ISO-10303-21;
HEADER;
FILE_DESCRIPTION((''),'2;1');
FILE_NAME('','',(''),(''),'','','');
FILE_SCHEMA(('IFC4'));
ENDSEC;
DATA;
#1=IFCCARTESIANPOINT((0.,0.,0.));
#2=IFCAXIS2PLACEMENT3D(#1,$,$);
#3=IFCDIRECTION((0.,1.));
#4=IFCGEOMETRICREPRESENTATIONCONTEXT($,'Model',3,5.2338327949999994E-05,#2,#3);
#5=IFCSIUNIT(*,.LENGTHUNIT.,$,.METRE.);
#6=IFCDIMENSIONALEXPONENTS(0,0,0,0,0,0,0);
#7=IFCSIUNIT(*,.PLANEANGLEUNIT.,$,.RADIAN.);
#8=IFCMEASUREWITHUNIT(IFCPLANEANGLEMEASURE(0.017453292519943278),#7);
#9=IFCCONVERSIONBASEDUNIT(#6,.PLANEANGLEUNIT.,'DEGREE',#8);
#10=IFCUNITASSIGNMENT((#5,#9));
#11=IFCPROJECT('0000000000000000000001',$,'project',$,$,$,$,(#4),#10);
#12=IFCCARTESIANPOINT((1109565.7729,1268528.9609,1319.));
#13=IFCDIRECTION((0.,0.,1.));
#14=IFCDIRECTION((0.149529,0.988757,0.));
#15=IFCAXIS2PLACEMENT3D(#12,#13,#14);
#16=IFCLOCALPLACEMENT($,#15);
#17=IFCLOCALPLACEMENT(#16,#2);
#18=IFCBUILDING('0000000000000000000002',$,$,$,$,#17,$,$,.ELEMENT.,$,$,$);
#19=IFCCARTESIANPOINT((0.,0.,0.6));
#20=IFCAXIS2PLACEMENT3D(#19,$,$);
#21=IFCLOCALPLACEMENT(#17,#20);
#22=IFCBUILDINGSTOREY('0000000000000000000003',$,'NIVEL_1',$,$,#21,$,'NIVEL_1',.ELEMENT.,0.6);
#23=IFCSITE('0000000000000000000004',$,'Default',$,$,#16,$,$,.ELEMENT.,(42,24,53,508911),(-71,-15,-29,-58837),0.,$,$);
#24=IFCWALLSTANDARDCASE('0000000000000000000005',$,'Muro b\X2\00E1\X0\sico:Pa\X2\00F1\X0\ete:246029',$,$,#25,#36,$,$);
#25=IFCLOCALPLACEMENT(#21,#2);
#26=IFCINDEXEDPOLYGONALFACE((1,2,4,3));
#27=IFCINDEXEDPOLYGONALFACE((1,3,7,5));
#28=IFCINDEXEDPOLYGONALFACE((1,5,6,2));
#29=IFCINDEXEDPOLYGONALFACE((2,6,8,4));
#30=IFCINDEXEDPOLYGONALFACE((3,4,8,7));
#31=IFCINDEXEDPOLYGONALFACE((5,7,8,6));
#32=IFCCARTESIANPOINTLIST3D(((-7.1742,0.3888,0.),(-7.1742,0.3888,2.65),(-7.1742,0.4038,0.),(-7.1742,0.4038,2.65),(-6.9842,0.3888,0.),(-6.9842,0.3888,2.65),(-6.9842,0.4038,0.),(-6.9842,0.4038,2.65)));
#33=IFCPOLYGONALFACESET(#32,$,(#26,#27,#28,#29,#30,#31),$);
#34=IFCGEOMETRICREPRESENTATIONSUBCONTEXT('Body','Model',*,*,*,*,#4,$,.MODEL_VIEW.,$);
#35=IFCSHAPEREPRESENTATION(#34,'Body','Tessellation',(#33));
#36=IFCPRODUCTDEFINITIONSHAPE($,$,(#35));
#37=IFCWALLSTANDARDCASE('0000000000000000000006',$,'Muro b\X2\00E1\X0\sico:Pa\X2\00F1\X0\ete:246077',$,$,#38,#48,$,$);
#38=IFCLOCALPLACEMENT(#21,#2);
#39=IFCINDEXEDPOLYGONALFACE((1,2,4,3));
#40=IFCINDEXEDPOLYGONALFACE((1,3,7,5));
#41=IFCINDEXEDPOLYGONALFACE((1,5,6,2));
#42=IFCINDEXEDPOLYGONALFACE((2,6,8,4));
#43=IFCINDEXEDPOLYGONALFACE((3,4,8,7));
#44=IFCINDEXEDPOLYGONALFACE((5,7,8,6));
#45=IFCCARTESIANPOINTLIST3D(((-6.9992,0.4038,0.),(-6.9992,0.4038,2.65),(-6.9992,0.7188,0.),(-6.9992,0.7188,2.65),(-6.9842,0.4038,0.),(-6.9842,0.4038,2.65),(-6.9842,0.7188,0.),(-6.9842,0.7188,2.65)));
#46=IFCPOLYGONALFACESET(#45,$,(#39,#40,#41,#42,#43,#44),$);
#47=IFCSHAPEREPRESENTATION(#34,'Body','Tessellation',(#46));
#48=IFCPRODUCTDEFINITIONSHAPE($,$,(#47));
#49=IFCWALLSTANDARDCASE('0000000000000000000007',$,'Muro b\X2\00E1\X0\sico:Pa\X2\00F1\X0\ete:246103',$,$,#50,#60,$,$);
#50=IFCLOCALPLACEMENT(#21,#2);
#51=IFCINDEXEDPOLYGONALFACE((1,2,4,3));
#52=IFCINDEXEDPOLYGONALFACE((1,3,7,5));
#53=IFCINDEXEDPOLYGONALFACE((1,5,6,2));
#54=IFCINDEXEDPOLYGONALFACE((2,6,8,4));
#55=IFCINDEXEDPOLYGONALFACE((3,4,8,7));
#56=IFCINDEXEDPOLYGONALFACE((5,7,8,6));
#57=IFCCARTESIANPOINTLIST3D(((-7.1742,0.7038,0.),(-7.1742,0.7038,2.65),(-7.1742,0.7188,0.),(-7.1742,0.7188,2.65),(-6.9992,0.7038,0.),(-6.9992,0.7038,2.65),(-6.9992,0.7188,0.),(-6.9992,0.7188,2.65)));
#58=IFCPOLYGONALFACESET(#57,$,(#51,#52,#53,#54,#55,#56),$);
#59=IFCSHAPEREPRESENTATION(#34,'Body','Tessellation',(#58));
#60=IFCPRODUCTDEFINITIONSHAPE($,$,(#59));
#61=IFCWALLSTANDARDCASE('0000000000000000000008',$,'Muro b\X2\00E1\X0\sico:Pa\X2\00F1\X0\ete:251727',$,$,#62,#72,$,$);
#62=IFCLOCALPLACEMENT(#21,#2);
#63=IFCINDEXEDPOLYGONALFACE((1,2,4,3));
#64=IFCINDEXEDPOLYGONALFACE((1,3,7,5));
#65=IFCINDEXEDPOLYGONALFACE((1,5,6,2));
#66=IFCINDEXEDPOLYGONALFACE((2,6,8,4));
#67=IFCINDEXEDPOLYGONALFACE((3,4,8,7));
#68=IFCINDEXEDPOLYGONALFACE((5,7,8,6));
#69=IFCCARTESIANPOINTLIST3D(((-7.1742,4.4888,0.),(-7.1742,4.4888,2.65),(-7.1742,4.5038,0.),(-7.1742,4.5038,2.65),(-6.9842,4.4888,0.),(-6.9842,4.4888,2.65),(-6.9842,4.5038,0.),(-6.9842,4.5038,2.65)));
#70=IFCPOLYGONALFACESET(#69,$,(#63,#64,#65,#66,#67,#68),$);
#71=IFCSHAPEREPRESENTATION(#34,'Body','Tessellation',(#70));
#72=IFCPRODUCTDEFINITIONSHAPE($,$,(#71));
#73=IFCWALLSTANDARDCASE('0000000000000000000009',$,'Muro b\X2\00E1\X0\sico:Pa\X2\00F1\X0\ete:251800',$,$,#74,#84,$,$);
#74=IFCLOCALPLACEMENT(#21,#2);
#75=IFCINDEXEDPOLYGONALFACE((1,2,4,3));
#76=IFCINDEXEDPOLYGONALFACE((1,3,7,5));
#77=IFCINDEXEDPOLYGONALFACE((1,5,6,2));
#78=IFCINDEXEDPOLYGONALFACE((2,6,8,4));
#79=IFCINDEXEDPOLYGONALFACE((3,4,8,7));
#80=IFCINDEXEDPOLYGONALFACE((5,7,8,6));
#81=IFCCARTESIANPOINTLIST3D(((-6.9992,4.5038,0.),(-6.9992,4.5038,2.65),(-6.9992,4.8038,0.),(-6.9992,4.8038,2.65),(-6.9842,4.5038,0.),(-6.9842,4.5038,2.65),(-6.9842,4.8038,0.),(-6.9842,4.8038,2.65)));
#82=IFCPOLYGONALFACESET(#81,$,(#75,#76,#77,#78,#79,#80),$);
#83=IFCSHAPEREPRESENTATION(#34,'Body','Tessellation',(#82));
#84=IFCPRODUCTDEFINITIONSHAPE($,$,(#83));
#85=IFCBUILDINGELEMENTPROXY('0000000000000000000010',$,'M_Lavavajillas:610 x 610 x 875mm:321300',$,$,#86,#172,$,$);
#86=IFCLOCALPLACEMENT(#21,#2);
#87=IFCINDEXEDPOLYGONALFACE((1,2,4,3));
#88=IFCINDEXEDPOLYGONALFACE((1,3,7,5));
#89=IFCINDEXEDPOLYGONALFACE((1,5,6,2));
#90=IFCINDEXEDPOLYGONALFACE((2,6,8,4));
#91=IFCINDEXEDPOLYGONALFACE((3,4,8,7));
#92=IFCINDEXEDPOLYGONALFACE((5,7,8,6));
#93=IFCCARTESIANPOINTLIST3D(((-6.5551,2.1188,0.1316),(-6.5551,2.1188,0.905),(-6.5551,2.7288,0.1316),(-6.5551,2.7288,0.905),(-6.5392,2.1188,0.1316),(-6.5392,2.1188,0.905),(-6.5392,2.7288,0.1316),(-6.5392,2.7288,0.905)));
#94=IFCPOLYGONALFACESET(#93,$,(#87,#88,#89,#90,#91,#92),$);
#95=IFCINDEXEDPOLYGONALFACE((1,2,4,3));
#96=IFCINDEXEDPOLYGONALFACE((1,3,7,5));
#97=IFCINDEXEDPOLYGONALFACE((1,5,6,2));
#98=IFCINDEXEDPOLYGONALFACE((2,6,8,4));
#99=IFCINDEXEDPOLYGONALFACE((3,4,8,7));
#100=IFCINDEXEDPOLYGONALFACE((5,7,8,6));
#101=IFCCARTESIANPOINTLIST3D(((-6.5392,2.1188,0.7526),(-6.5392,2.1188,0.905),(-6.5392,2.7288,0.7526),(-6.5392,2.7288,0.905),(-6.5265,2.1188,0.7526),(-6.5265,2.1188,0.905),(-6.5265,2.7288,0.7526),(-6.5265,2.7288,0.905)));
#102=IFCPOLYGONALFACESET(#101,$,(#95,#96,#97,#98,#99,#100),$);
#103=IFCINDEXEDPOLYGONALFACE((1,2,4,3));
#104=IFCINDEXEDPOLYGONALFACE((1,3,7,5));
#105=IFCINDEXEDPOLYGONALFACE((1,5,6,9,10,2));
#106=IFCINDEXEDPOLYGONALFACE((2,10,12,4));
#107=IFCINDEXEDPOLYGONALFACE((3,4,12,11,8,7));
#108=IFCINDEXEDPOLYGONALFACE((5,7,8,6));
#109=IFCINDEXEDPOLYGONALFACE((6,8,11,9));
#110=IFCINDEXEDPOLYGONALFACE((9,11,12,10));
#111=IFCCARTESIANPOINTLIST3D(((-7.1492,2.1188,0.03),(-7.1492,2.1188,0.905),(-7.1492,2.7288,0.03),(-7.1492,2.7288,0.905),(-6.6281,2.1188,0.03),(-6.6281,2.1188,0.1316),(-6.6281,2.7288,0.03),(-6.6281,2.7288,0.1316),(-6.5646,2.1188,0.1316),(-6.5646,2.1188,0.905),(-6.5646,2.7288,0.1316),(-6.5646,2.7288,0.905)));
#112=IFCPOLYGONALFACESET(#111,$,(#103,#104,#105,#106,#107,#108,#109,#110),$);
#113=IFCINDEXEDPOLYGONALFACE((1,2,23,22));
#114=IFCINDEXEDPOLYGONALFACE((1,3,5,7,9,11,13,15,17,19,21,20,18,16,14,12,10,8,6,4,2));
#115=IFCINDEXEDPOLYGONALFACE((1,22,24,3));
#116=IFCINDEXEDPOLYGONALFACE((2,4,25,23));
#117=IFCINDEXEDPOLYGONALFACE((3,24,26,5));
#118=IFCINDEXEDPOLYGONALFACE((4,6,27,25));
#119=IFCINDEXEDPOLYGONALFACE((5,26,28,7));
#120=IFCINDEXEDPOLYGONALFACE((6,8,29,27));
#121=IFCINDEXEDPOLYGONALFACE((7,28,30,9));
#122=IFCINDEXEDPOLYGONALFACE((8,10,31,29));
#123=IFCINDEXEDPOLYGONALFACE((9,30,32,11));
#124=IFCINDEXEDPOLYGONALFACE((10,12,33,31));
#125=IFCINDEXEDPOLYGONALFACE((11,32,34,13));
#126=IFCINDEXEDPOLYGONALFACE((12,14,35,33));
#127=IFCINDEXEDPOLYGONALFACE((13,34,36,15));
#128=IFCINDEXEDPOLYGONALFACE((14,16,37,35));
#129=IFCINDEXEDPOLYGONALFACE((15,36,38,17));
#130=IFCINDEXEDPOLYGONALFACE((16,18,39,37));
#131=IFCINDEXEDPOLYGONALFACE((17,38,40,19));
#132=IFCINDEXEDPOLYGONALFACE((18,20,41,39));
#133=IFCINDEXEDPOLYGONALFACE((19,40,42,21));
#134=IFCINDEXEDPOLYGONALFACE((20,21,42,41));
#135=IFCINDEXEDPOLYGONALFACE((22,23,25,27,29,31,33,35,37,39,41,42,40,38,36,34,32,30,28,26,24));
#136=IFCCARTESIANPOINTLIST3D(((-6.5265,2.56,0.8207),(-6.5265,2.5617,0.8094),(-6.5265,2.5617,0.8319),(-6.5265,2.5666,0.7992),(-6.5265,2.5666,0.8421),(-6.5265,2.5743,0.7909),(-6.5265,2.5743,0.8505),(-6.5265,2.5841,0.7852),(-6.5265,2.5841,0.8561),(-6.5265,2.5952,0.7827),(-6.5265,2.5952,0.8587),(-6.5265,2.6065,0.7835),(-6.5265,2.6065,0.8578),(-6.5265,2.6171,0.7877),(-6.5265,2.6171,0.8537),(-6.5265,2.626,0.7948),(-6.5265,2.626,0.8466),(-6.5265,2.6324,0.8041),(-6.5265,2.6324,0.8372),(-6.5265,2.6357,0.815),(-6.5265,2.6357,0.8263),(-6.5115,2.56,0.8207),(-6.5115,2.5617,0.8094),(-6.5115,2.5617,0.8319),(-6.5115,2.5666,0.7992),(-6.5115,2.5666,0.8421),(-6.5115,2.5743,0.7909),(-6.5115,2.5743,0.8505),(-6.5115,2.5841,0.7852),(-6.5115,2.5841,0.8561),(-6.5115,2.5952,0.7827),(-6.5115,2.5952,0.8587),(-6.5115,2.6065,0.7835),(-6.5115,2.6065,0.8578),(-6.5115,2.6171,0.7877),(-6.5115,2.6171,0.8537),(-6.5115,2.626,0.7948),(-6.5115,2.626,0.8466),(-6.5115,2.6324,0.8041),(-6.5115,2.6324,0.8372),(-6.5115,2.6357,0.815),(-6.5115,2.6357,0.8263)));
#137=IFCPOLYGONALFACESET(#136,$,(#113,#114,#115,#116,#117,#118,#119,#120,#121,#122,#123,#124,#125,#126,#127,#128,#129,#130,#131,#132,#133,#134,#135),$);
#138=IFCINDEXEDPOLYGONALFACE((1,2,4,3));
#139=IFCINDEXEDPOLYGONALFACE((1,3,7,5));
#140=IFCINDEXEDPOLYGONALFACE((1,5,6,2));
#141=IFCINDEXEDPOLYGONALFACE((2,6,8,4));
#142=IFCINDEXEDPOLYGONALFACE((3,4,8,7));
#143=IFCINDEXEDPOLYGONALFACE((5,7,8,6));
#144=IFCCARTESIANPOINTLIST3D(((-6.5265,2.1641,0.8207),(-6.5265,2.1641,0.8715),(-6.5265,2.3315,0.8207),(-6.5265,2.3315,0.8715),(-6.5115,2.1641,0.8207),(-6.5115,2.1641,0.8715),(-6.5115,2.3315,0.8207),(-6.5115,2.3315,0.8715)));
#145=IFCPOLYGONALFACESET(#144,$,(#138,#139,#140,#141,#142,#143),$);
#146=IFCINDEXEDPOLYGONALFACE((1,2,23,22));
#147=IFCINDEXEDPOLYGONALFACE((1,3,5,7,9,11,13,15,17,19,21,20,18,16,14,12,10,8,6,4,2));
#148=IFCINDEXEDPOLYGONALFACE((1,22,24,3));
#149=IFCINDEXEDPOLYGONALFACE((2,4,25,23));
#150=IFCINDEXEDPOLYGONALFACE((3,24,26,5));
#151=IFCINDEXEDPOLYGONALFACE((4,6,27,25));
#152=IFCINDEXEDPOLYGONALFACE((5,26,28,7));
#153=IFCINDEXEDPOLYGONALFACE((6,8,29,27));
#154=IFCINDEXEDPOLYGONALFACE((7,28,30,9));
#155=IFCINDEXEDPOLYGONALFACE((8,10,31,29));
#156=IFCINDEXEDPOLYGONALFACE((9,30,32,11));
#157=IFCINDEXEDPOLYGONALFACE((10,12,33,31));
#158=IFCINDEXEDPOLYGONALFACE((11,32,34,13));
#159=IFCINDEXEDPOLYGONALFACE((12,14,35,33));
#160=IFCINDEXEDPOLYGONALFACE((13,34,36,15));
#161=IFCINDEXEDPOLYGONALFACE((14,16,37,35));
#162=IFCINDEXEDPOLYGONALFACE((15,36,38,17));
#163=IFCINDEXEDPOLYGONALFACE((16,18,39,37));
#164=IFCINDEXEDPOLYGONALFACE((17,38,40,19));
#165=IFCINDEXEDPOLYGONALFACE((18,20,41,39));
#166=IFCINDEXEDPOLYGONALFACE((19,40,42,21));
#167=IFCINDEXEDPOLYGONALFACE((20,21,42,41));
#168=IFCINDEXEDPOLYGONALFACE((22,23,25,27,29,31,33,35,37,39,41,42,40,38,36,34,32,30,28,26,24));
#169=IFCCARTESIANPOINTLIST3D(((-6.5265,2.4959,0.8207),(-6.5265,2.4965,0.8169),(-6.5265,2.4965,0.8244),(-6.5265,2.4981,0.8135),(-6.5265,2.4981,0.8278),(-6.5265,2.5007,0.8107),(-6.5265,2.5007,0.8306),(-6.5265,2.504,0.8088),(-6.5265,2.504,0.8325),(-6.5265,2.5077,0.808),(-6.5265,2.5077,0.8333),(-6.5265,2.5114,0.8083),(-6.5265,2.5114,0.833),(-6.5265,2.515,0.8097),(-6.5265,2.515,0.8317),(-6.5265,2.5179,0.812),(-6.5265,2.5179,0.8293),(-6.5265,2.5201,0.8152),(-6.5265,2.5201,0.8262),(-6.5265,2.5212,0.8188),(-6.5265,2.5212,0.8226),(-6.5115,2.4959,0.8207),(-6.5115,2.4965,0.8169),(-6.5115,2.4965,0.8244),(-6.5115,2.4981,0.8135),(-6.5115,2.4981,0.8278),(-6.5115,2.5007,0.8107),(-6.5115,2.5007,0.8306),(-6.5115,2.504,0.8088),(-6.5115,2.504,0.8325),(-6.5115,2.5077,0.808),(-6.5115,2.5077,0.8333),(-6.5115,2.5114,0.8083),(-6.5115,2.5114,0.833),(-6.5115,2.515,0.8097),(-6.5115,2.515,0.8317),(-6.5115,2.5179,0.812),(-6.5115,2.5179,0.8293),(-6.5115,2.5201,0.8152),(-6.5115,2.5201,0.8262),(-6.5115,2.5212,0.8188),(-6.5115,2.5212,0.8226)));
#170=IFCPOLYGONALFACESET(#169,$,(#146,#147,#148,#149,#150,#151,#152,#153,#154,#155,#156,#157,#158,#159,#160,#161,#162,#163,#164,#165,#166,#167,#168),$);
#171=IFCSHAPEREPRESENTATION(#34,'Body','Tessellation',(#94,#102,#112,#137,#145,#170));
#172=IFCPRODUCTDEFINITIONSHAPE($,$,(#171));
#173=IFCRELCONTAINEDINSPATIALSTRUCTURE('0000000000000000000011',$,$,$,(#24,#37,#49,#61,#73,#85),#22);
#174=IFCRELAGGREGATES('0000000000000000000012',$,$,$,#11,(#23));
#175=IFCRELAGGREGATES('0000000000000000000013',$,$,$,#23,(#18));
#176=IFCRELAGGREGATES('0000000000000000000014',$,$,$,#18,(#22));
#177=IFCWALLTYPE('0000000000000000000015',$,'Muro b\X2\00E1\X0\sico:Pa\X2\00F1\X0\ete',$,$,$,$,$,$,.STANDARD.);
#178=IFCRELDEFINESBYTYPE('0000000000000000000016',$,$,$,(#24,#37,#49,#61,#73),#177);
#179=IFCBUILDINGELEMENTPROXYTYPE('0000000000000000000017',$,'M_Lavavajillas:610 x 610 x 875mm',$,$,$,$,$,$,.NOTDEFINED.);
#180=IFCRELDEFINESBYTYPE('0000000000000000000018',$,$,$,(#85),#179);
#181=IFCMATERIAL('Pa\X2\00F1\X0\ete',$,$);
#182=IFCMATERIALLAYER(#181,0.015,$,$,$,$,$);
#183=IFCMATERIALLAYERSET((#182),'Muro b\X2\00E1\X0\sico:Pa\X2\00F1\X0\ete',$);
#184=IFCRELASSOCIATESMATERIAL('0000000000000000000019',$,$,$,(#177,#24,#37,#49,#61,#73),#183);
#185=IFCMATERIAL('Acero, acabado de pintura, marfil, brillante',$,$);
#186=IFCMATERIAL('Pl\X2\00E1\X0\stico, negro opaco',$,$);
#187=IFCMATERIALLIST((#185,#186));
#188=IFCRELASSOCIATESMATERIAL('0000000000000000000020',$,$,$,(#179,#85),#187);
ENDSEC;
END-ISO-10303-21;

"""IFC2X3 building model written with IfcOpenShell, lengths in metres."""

from ifc_helpers import new_model, entity, si_unit, converted_unit, direction, frame, frame_2d, origin, origin_2d_with_axis, place, context, subcontext, project, spatial, polyline, rectangle, circle, outline, extrude, source, transform, mapped, material, material_list, layer, layer_set, layer_usage, type_object, type_shapes, element, save


model = new_model("IFC2X3")

# Units and contexts
model_context = context("Model", 3, precision=5.2338327949999994e-05, world=origin(), true_north=direction((0.0, 1.0)))
body_context = subcontext(model_context, "Body", "Model", "MODEL_VIEW")
ifc_project = project(units=[si_unit("LENGTHUNIT", "METRE"), converted_unit("PLANEANGLEUNIT", "DEGREE", entity("IfcPlaneAngleMeasure", 0.017453292519943278), si_unit("PLANEANGLEUNIT", "RADIAN"), dimensions=[0, 0, 0, 0, 0, 0, 0])], contexts=[model_context])

# Site, building, storey
site_placement = place(None, frame((1109565.7729, 1268528.9609, 1319.0), z_axis=(0.0, 0.0, 1.0), x_axis=(0.149529, 0.988757, 0.0)))
site = spatial("IfcSite", under=ifc_project, at=site_placement, Name="Default", CompositionType="ELEMENT", RefLatitude=(42, 24, 53, 508911), RefLongitude=(-71, -15, -29, -58837), RefElevation=0.0)
building_placement = place(site_placement, origin())
building = spatial("IfcBuilding", under=site, at=building_placement, CompositionType="ELEMENT")
storey_placement = place(building_placement, frame((0.0, 0.0, 0.6)))
storey = spatial("IfcBuildingStorey", under=building, at=storey_placement, Name="NIVEL_1", LongName="NIVEL_1", CompositionType="ELEMENT", Elevation=0.6)

# Shared definitions
ifc_material_1 = material(Name="Pañete")

# Walls
ifc_layer_1 = layer(ifc_material_1, 0.015)
ifc_layer_set_1 = layer_set([ifc_layer_1], Name="Muro básico:Pañete")
wall_type_1 = type_object("IfcWallType", Name="Muro básico:Pañete", PredefinedType="STANDARD", material=ifc_layer_set_1)
ifc_layer_usage_1 = layer_usage(ifc_layer_set_1, "AXIS2", "POSITIVE", -0.0075)
wall_1_placement = place(storey_placement, frame((-7.1742, 0.3963, 0.0)))
element("IfcWallStandardCase", 1, at=wall_1_placement, inside=storey, type_object=wall_type_1, material=ifc_layer_usage_1, Name="Muro básico:Pañete:246029", context=body_context, shape_type="SweptSolid", body=[
    extrude(rectangle(XDim=0.19, YDim=0.015, at=frame_2d((0.095, 0.0), x_axis=(-1.0, 0.0))), origin(), (0.0, 0.0, 1.0), 2.65),
])
ifc_layer_usage_2 = layer_usage(ifc_layer_set_1, "AXIS2", "POSITIVE", -0.0075)
wall_2_placement = place(storey_placement, frame((-6.9917, 0.4038, 0.0), z_axis=(0.0, 0.0, 1.0), x_axis=(0.0, 1.0, 0.0)))
element("IfcWallStandardCase", 2, at=wall_2_placement, inside=storey, type_object=wall_type_1, material=ifc_layer_usage_2, Name="Muro básico:Pañete:246077", context=body_context, shape_type="SweptSolid", body=[
    extrude(rectangle(XDim=0.315, YDim=0.015, at=frame_2d((0.1575, 0.0), x_axis=(-1.0, 0.0))), origin(), (0.0, 0.0, 1.0), 2.65),
])
ifc_layer_usage_3 = layer_usage(ifc_layer_set_1, "AXIS2", "POSITIVE", -0.0075)
wall_3_placement = place(storey_placement, frame((-6.9992, 0.7113, 0.0), z_axis=(0.0, 0.0, 1.0), x_axis=(-1.0, 0.0, 0.0)))
element("IfcWallStandardCase", 3, at=wall_3_placement, inside=storey, type_object=wall_type_1, material=ifc_layer_usage_3, Name="Muro básico:Pañete:246103", context=body_context, shape_type="SweptSolid", body=[
    extrude(rectangle(XDim=0.175, YDim=0.015, at=frame_2d((0.0875, 0.0), x_axis=(-1.0, 0.0))), origin(), (0.0, 0.0, 1.0), 2.65),
])
ifc_layer_usage_4 = layer_usage(ifc_layer_set_1, "AXIS2", "POSITIVE", -0.0075)
wall_4_placement = place(storey_placement, frame((-7.1742, 4.4963, 0.0)))
element("IfcWallStandardCase", 4, at=wall_4_placement, inside=storey, type_object=wall_type_1, material=ifc_layer_usage_4, Name="Muro básico:Pañete:251727", context=body_context, shape_type="SweptSolid", body=[
    extrude(rectangle(XDim=0.19, YDim=0.015, at=frame_2d((0.095, 0.0), x_axis=(-1.0, 0.0))), origin(), (0.0, 0.0, 1.0), 2.65),
])
ifc_layer_usage_5 = layer_usage(ifc_layer_set_1, "AXIS2", "POSITIVE", -0.0075)
wall_5_placement = place(storey_placement, frame((-6.9917, 4.5038, 0.0), z_axis=(0.0, 0.0, 1.0), x_axis=(0.0, 1.0, 0.0)))
element("IfcWallStandardCase", 5, at=wall_5_placement, inside=storey, type_object=wall_type_1, material=ifc_layer_usage_5, Name="Muro básico:Pañete:251800", context=body_context, shape_type="SweptSolid", body=[
    extrude(rectangle(XDim=0.3, YDim=0.015, at=frame_2d((0.15, 0.0), x_axis=(-1.0, 0.0))), origin(), (0.0, 0.0, 1.0), 2.65),
])

# Building element proxy
ifc_material_2 = material(Name="Acero, acabado de pintura, marfil, brillante")
ifc_material_3 = material(Name="Plástico, negro opaco")
ifc_material_list_1 = material_list([ifc_material_2, ifc_material_3])
building_element_proxy_type = type_object("IfcBuildingElementProxyType", Name="M_Lavavajillas:610 x 610 x 875mm", PredefinedType="NOTDEFINED", material=ifc_material_list_1)
shared_shape_1 = source(origin(), body_context, "Body", "SweptSolid", [
    extrude(rectangle(XDim=0.0159, YDim=0.61, at=origin_2d_with_axis()), frame((0.3825, -0.0304, 0.1016), z_axis=(0.0, 0.0, 1.0), x_axis=(0.0, 1.0, 0.0)), (0.0, 0.0, 1.0), 0.7734),
    extrude(rectangle(XDim=0.61, YDim=0.0127, at=origin_2d_with_axis()), frame((0.3825, -0.0447, 0.7226), z_axis=(0.0, 0.0, 1.0), x_axis=(-1.0, 0.0, 0.0)), (0.0, 0.0, 1.0), 0.1524),
    extrude(outline(polyline([(-0.3255, -0.3686), (0.5495, -0.3686), (0.5495, 0.216), (-0.2239, 0.216), (-0.2239, 0.1525), (-0.3255, 0.1525), (-0.3255, -0.3686)])), frame((0.0775, 0.2031, 0.3255), z_axis=(1.0, 0.0, 0.0), x_axis=(0.0, 0.0, 1.0)), (0.0, 0.0, 1.0), 0.61),
    extrude(circle(Radius=0.0381, at=frame_2d((0.0, 0.0), x_axis=(1.0, 0.0))), frame((0.5568, -0.0661, 0.7907), z_axis=(0.0, 1.0, 0.0), x_axis=(-1.0, 0.0, 0.0)), (0.0, 0.0, 1.0), 0.015),
    extrude(rectangle(XDim=0.015, YDim=0.1674, at=frame_2d((0.0, 0.0), x_axis=(1.0, 0.0))), frame((0.2065, -0.0586, 0.7907), z_axis=(0.0, 0.0, 1.0), x_axis=(0.0, 1.0, 0.0)), (0.0, 0.0, 1.0), 0.0508),
    extrude(circle(Radius=0.0127, at=frame_2d((0.0, 0.0), x_axis=(1.0, 0.0))), frame((0.4673, -0.0661, 0.7907), z_axis=(0.0, 1.0, 0.0), x_axis=(-1.0, 0.0, 0.0)), (0.0, 0.0, 1.0), 0.015),
])
type_shapes(building_element_proxy_type, [shared_shape_1])
proxy_placement = place(storey_placement, frame((-6.5776, 2.0413, 0.03), z_axis=(0.0, 0.0, 1.0), x_axis=(0.0, 1.0, 0.0)))
element("IfcBuildingElementProxy", 6, at=proxy_placement, inside=storey, type_object=building_element_proxy_type, material=ifc_material_list_1, Name="M_Lavavajillas:610 x 610 x 875mm:321300", context=body_context, shape_type="MappedRepresentation", body=[
    mapped(shared_shape_1, transform((0.0, 0.0, 0.0), scale=1.0)),
])

save(model, "model.ifc")
